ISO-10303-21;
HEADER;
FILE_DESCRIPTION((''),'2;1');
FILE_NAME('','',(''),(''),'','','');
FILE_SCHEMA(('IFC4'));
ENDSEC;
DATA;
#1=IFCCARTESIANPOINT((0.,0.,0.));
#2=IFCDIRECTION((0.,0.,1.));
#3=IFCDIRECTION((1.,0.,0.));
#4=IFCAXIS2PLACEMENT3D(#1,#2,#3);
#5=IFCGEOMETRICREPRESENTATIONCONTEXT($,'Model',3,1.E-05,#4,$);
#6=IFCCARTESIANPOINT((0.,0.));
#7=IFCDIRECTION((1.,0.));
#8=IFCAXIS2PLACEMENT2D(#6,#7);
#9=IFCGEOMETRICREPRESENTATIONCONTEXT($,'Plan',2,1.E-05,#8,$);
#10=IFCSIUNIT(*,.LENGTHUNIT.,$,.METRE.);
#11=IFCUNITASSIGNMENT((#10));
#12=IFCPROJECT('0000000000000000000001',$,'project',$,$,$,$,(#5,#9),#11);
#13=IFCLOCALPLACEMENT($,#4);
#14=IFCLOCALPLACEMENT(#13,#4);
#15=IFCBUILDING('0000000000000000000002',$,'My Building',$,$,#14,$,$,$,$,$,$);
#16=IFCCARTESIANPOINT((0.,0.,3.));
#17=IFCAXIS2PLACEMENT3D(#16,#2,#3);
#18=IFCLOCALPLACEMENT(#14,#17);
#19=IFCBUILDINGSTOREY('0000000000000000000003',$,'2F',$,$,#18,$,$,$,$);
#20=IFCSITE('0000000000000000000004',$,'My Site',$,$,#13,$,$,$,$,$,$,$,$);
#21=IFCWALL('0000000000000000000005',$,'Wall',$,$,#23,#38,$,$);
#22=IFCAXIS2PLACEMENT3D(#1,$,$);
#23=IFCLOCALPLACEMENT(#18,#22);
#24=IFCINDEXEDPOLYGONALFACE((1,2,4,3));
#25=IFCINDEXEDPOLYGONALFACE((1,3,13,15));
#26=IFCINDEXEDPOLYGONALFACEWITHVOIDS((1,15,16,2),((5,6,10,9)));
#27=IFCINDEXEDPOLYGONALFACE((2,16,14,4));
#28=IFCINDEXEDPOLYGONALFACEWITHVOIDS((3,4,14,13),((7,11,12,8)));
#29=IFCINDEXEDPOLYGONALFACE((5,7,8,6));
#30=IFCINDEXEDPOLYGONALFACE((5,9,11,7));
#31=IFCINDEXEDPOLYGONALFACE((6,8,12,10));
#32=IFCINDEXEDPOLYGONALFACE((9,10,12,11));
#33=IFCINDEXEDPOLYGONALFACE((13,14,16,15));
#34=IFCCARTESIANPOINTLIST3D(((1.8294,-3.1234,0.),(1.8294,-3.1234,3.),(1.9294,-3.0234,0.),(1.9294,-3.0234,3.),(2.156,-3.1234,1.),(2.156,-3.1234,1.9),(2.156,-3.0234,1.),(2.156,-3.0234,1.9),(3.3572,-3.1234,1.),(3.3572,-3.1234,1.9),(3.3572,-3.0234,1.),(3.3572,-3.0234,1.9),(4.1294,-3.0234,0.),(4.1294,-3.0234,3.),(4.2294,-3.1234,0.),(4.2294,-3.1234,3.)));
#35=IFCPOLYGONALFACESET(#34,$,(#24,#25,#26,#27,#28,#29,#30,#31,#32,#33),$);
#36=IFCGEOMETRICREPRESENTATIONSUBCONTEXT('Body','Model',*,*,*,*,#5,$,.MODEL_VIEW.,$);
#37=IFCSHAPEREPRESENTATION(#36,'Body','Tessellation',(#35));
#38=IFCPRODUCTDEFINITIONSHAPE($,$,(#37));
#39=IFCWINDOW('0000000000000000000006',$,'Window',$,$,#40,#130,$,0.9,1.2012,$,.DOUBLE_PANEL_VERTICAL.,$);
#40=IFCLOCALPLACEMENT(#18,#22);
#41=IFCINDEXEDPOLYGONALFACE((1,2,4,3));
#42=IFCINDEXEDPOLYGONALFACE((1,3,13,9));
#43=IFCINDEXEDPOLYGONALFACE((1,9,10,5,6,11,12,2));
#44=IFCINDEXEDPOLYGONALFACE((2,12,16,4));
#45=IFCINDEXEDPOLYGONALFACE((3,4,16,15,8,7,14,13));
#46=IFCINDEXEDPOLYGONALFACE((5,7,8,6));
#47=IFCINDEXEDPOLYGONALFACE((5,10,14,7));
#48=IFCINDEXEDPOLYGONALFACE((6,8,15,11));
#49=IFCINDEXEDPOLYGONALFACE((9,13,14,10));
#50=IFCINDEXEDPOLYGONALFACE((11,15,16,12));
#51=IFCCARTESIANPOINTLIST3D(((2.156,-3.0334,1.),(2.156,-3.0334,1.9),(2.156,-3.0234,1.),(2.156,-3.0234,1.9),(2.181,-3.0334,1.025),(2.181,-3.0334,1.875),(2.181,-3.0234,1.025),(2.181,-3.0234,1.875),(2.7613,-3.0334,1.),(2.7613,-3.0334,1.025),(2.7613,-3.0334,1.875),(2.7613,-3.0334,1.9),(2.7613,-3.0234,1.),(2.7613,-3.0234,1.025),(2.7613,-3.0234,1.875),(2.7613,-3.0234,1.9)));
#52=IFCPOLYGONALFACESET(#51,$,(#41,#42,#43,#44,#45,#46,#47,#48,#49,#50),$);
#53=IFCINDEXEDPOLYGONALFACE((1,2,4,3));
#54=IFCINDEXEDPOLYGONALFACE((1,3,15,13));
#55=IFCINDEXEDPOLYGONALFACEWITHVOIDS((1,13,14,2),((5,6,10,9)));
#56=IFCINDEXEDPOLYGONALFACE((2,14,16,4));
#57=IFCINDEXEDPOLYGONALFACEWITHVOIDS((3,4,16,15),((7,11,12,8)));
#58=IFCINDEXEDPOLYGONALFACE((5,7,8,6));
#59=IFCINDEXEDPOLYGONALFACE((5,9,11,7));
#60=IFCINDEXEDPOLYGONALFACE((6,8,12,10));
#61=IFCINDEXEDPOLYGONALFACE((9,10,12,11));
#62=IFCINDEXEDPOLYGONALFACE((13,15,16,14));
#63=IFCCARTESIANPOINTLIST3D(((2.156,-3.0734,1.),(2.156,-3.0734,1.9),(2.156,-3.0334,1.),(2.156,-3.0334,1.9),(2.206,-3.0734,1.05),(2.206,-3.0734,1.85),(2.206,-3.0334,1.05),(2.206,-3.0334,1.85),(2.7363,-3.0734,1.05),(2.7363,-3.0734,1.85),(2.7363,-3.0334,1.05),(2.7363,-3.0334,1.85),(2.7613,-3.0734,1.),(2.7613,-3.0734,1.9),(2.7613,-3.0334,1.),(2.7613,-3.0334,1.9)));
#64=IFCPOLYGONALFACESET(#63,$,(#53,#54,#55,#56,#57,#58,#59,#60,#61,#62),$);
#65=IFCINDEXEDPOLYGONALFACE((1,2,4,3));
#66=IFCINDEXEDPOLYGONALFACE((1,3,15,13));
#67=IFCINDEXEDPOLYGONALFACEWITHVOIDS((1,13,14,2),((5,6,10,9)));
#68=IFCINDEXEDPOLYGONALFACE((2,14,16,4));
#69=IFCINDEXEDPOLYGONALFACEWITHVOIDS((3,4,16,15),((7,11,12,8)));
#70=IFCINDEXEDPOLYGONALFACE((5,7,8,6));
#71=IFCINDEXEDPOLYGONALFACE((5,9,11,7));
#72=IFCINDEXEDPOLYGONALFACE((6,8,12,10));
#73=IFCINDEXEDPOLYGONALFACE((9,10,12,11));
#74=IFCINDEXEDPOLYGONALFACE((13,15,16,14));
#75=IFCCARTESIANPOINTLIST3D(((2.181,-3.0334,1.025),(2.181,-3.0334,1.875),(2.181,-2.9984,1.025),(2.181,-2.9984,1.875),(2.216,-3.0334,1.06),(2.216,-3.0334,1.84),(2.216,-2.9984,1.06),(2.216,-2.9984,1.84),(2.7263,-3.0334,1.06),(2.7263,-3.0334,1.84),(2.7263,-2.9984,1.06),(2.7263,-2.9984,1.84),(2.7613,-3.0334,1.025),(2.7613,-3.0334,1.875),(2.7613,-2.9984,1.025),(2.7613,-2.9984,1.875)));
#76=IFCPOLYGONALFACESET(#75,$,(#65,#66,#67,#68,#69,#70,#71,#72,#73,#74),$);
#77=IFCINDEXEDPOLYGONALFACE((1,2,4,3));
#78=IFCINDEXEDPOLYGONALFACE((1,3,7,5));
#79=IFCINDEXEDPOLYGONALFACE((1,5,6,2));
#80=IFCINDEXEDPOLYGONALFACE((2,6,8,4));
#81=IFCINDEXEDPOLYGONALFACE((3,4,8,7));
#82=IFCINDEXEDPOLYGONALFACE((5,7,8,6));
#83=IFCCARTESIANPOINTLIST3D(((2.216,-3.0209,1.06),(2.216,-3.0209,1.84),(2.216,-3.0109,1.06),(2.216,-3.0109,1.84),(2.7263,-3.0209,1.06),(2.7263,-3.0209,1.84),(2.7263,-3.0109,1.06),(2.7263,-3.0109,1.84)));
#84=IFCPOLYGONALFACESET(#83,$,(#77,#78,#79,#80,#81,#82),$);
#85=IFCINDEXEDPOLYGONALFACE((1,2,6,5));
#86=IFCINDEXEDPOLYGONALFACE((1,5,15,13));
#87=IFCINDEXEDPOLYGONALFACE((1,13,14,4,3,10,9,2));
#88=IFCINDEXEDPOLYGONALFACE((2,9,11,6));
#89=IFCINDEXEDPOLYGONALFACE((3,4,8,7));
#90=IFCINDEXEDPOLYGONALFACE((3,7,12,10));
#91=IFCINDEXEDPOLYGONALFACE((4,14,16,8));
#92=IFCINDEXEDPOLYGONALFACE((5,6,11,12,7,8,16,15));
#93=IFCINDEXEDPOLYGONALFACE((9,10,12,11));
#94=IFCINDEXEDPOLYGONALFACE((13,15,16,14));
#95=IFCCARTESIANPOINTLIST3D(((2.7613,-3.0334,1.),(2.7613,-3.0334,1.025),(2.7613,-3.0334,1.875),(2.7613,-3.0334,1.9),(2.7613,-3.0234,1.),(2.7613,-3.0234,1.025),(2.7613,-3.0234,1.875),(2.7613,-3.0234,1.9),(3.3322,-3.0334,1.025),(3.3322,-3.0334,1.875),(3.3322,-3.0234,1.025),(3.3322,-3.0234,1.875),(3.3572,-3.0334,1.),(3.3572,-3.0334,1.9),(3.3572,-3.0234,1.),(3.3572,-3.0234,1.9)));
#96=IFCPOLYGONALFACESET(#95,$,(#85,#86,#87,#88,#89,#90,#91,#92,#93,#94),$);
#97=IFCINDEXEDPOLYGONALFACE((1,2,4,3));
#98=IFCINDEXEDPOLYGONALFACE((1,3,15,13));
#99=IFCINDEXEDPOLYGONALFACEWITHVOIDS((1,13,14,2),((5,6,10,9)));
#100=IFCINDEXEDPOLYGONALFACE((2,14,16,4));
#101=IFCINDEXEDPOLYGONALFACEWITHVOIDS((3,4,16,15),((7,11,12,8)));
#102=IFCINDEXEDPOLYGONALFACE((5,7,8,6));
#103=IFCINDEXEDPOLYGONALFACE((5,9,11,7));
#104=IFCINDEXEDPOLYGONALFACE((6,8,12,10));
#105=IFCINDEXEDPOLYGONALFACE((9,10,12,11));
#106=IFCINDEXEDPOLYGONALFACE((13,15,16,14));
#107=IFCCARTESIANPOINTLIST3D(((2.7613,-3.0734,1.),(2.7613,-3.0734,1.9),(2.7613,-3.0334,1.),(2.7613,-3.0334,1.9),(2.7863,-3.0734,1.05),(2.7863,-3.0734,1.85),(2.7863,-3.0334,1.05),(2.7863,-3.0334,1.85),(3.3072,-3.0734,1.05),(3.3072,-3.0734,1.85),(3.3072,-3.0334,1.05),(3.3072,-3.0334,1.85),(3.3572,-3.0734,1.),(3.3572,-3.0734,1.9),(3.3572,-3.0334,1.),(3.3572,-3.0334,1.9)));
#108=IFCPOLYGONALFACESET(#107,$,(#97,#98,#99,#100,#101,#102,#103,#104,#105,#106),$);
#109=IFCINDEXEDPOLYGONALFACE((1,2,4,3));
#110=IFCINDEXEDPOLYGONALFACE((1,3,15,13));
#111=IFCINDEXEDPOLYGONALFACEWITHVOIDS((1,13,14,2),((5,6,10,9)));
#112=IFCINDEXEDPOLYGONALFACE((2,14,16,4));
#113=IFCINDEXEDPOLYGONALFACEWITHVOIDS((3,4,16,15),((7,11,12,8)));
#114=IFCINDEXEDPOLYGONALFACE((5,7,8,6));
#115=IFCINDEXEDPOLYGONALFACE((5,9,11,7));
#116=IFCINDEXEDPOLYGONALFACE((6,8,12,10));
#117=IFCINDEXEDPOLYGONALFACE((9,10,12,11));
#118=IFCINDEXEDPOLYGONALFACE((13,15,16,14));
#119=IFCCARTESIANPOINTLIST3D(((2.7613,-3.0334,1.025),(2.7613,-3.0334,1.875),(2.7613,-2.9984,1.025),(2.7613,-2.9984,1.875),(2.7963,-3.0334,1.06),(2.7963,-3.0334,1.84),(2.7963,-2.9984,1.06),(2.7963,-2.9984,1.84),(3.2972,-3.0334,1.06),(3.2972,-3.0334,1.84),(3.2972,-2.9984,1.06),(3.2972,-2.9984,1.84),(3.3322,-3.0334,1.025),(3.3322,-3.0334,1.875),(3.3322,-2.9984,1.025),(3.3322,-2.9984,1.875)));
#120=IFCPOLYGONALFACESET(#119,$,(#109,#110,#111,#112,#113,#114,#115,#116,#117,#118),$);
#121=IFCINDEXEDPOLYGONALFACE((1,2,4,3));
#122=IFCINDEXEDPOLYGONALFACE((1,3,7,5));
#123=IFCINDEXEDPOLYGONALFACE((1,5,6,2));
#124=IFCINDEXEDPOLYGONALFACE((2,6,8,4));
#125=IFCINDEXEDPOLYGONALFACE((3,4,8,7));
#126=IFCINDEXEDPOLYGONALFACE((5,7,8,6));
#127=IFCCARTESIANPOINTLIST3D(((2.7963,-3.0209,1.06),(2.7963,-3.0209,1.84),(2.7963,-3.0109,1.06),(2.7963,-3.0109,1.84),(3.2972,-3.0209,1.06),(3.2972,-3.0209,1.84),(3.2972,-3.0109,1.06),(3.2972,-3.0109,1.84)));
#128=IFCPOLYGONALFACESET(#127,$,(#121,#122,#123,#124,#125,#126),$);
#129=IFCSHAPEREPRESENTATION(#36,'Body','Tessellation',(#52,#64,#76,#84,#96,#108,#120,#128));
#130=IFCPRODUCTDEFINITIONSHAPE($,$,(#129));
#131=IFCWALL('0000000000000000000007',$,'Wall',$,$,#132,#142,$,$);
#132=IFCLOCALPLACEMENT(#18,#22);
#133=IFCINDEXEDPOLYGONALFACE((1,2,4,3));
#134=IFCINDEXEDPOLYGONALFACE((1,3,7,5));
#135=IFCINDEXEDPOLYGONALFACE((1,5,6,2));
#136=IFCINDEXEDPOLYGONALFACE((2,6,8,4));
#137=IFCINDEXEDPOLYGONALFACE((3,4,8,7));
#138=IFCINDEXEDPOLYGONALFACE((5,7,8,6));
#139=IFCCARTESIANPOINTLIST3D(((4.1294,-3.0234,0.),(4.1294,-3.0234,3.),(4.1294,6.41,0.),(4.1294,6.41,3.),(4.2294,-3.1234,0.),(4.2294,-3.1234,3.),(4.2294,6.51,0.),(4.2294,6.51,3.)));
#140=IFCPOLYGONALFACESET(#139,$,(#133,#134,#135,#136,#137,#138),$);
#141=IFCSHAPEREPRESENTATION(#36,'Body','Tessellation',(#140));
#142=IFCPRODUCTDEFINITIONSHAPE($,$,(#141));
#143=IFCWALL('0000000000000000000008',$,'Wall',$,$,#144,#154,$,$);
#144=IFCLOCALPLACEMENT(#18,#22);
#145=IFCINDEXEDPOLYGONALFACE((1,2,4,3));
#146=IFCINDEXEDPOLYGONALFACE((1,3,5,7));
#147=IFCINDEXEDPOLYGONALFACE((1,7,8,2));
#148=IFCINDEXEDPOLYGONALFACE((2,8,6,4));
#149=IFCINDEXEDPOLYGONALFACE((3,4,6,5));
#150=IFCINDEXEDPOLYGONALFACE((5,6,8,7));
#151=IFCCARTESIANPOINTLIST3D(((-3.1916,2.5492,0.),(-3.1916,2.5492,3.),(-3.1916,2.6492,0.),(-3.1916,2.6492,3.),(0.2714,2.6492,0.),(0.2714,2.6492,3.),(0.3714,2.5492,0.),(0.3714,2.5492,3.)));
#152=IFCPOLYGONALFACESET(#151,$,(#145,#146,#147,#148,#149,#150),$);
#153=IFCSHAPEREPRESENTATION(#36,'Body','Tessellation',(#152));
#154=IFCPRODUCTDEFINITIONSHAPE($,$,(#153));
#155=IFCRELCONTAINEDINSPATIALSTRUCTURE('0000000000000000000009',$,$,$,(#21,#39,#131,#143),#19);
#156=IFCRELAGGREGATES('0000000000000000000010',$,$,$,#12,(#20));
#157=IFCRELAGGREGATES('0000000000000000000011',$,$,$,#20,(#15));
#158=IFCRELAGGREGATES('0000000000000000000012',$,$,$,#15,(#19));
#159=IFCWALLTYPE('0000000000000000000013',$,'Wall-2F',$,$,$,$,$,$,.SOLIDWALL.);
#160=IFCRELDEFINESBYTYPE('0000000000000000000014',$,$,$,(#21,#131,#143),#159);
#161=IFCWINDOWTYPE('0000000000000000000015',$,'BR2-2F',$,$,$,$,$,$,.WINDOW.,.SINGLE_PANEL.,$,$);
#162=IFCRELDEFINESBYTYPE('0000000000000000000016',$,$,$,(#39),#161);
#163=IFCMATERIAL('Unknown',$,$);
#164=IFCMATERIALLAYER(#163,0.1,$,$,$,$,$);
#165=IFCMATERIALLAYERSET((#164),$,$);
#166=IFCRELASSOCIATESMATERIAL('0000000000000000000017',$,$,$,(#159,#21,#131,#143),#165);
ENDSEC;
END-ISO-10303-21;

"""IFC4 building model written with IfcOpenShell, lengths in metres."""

from ifc_helpers import new_model, entity, si_unit, frame, origin_with_axes, origin_2d_with_axis, place, context, subcontext, project, spatial, line, indexed_curve, outline, extrude, shape, source, transform, mapped, material, layer, layer_set, layer_usage, type_object, type_shapes, element, fill, save


model = new_model("IFC4")

# Units and contexts
model_context = context("Model", 3, precision=1e-05, world=origin_with_axes())
plan_context = context("Plan", 2, precision=1e-05, world=origin_2d_with_axis())
body_context_1 = subcontext(model_context, "Body", "Model", "MODEL_VIEW")
body_context_2 = subcontext(plan_context, "Body", "Plan", "PLAN_VIEW")
ifc_project = project(units=[si_unit("LENGTHUNIT", "METRE")], contexts=[model_context, plan_context])

# Site, building, storey
site_placement = place(None, origin_with_axes())
site = spatial("IfcSite", under=ifc_project, at=site_placement, Name="My Site")
building_placement = place(site_placement, origin_with_axes())
building = spatial("IfcBuilding", under=site, at=building_placement, Name="My Building")
storey_placement = place(building_placement, frame((0.0, 0.0, 3.0), z_axis=(0.0, 0.0, 1.0), x_axis=(1.0, 0.0, 0.0)))
storey = spatial("IfcBuildingStorey", under=building, at=storey_placement, Name="2F")

# Shared definitions
ifc_material = material(Name="Unknown")

# Shared definitions
ifc_layer = layer(ifc_material, 0.1)
ifc_layer_set = layer_set([ifc_layer])
wall_type = type_object("IfcWallType", Name="Wall-2F", PredefinedType="SOLIDWALL", material=ifc_layer_set)

# Wall, opening, window
ifc_layer_usage_1 = layer_usage(ifc_layer_set, "AXIS2", "POSITIVE", 0.0)
wall_1_placement = place(storey_placement, frame((1.8294, -3.1234, 0.0), z_axis=(0.0, 0.0, 1.0), x_axis=(1.0, 0.0, 0.0)))
wall_1 = element("IfcWall", 1, at=wall_1_placement, inside=storey, type_object=wall_type, material=ifc_layer_usage_1, Name="Wall", context=body_context_1, shape_type="SweptSolid", body=[
    extrude(outline(indexed_curve([(0.0, 0.0), (0.1, 0.1), (2.3, 0.1), (2.4, 0.0)], segments=[line(1, 2, 3, 4, 1)])), origin_with_axes(), (0.0, 0.0, 1.0), 3.0),
])
shared_shape_1 = source(origin_with_axes(), body_context_1, "Body", "SweptSolid", [
    extrude(outline(indexed_curve([(0.0, 0.0), (1.2012, 0.0), (1.2012, 0.9), (0.0, 0.9)], segments=[line(1, 2, 3, 4, 1)])), frame((0.0, -0.6, 0.0), z_axis=(0.0, -1.0, 0.0), x_axis=(1.0, 0.0, 0.0)), (0.0, 0.0, -1.0), 1.2),
])
opening_1_placement = place(wall_1_placement, frame((0.3266, 0.0, 1.0), z_axis=(0.0, 0.0, 1.0), x_axis=(1.0, 0.0, 0.0)))
opening_1 = element("IfcOpeningElement", 2, at=opening_1_placement, cuts=wall_1, PredefinedType="OPENING", context=body_context_1, shape_type="MappedRepresentation", body=[
    mapped(shared_shape_1, transform((0.0, 0.0, 0.0), x_axis=(1.0, 0.0, 0.0), y_axis=(0.0, 1.0, 0.0), z_axis=(0.0, 0.0, 1.0), scale=1.0)),
])
window_type = type_object("IfcWindowType", Name="BR2-2F", PartitioningType="SINGLE_PANEL", PredefinedType="WINDOW")
shared_shape_2 = source(origin_with_axes(), body_context_1, "Body", "SweptSolid", [
    extrude(outline(indexed_curve([(0.6053, 0.0), (0.0, 0.0), (0.0, 0.9), (0.6053, 0.9), (0.6053, 0.875), (0.025, 0.875), (0.025, 0.025), (0.6053, 0.025)], segments=[line(1, 2, 3, 4, 5, 6, 7, 8, 1)])), frame((0.0, 0.09, 0.0), z_axis=(0.0, -1.0, 0.0), x_axis=(1.0, 0.0, 0.0)), (0.0, 0.0, -1.0), 0.01),
    extrude(outline(indexed_curve([(0.0, 0.0), (0.6053, 0.0), (0.6053, 0.9), (0.0, 0.9)], segments=[line(1, 2, 3, 4, 1)]), holes=[indexed_curve([(0.05, 0.05), (0.5803, 0.05), (0.5803, 0.85), (0.05, 0.85)], segments=[line(1, 2, 3, 4, 1)])]), frame((0.0, 0.05, 0.0), z_axis=(0.0, -1.0, 0.0), x_axis=(1.0, 0.0, 0.0)), (0.0, 0.0, -1.0), 0.04),
    extrude(outline(indexed_curve([(0.0, 0.0), (0.5803, 0.0), (0.5803, 0.85), (0.0, 0.85)], segments=[line(1, 2, 3, 4, 1)]), holes=[indexed_curve([(0.035, 0.035), (0.5453, 0.035), (0.5453, 0.815), (0.035, 0.815)], segments=[line(1, 2, 3, 4, 1)])]), frame((0.025, 0.09, 0.025), z_axis=(0.0, -1.0, 0.0), x_axis=(1.0, 0.0, 0.0)), (0.0, 0.0, -1.0), 0.035),
    extrude(outline(indexed_curve([(0.035, 0.035), (0.5453, 0.035), (0.5453, 0.815), (0.035, 0.815)], segments=[line(1, 2, 3, 4, 1)])), frame((0.025, 0.1025, 0.025), z_axis=(0.0, -1.0, 0.0), x_axis=(1.0, 0.0, 0.0)), (0.0, 0.0, -1.0), 0.01),
    extrude(outline(indexed_curve([(0.0, 0.9), (0.5958, 0.9), (0.5958, 0.0), (0.0, 0.0), (0.0, 0.025), (0.5708, 0.025), (0.5708, 0.875), (0.0, 0.875)], segments=[line(1, 2, 3, 4, 5, 6, 7, 8, 1)])), frame((0.6053, 0.09, 0.0), z_axis=(0.0, -1.0, 0.0), x_axis=(1.0, 0.0, 0.0)), (0.0, 0.0, -1.0), 0.01),
    extrude(outline(indexed_curve([(0.0, 0.0), (0.5958, 0.0), (0.5958, 0.9), (0.0, 0.9)], segments=[line(1, 2, 3, 4, 1)]), holes=[indexed_curve([(0.025, 0.05), (0.5458, 0.05), (0.5458, 0.85), (0.025, 0.85)], segments=[line(1, 2, 3, 4, 1)])]), frame((0.6053, 0.05, 0.0), z_axis=(0.0, -1.0, 0.0), x_axis=(1.0, 0.0, 0.0)), (0.0, 0.0, -1.0), 0.04),
    extrude(outline(indexed_curve([(0.0, 0.0), (0.5708, 0.0), (0.5708, 0.85), (0.0, 0.85)], segments=[line(1, 2, 3, 4, 1)]), holes=[indexed_curve([(0.035, 0.035), (0.5358, 0.035), (0.5358, 0.815), (0.035, 0.815)], segments=[line(1, 2, 3, 4, 1)])]), frame((0.6053, 0.09, 0.025), z_axis=(0.0, -1.0, 0.0), x_axis=(1.0, 0.0, 0.0)), (0.0, 0.0, -1.0), 0.035),
    extrude(outline(indexed_curve([(0.035, 0.035), (0.5358, 0.035), (0.5358, 0.815), (0.035, 0.815)], segments=[line(1, 2, 3, 4, 1)])), frame((0.6053, 0.1025, 0.025), z_axis=(0.0, -1.0, 0.0), x_axis=(1.0, 0.0, 0.0)), (0.0, 0.0, -1.0), 0.01),
])
shared_shape_3 = source(origin_with_axes(), body_context_2, "Body", "Curve2D", [
    entity("IfcIndexedPolyCurve", entity("IfcCartesianPointList2D", [[0.05, 0.05], [0.5803, 0.05]])),
    entity("IfcIndexedPolyCurve", entity("IfcCartesianPointList2D", [[0.0, 0.1], [0.025, 0.1], [0.025, 0.09], [0.05, 0.09], [0.05, 0.05], [0.0, 0.05]]), [entity("IfcLineIndex", [1, 2, 3, 4, 5, 6, 1])]),
    entity("IfcIndexedPolyCurve", entity("IfcCartesianPointList2D", [[0.6053, 0.1], [0.6053, 0.1], [0.6053, 0.09], [0.5803, 0.09], [0.5803, 0.05], [0.6053, 0.05]])),
    entity("IfcIndexedPolyCurve", entity("IfcCartesianPointList2D", [[0.025, 0.09], [0.06, 0.09], [0.06, 0.125], [0.025, 0.125]]), [entity("IfcLineIndex", [1, 2, 3, 4, 1])]),
    entity("IfcIndexedPolyCurve", entity("IfcCartesianPointList2D", [[0.6053, 0.09], [0.5703, 0.09], [0.5703, 0.125], [0.6053, 0.125]]), [entity("IfcLineIndex", [1, 2, 3, 4, 1])]),
    entity("IfcIndexedPolyCurve", entity("IfcCartesianPointList2D", [[0.06, 0.09], [0.5703, 0.09]])),
    entity("IfcIndexedPolyCurve", entity("IfcCartesianPointList2D", [[0.06, 0.125], [0.5703, 0.125]])),
    entity("IfcIndexedPolyCurve", entity("IfcCartesianPointList2D", [[0.06, 0.1075], [0.5703, 0.1075]])),
    entity("IfcIndexedPolyCurve", entity("IfcCartesianPointList2D", [[0.6303, 0.05], [1.1512, 0.05]])),
    entity("IfcIndexedPolyCurve", entity("IfcCartesianPointList2D", [[0.6053, 0.1], [0.6053, 0.1], [0.6053, 0.09], [0.6303, 0.09], [0.6303, 0.05], [0.6053, 0.05]])),
    entity("IfcIndexedPolyCurve", entity("IfcCartesianPointList2D", [[1.2012, 0.1], [1.1762, 0.1], [1.1762, 0.09], [1.1512, 0.09], [1.1512, 0.05], [1.2012, 0.05]]), [entity("IfcLineIndex", [1, 2, 3, 4, 5, 6, 1])]),
    entity("IfcIndexedPolyCurve", entity("IfcCartesianPointList2D", [[0.6053, 0.09], [0.6403, 0.09], [0.6403, 0.125], [0.6053, 0.125]]), [entity("IfcLineIndex", [1, 2, 3, 4, 1])]),
    entity("IfcIndexedPolyCurve", entity("IfcCartesianPointList2D", [[1.1762, 0.09], [1.1412, 0.09], [1.1412, 0.125], [1.1762, 0.125]]), [entity("IfcLineIndex", [1, 2, 3, 4, 1])]),
    entity("IfcIndexedPolyCurve", entity("IfcCartesianPointList2D", [[0.6403, 0.09], [1.1412, 0.09]])),
    entity("IfcIndexedPolyCurve", entity("IfcCartesianPointList2D", [[0.6403, 0.125], [1.1412, 0.125]])),
    entity("IfcIndexedPolyCurve", entity("IfcCartesianPointList2D", [[0.6403, 0.1075], [1.1412, 0.1075]])),
])
type_shapes(window_type, [shared_shape_2, shared_shape_3])
window_placement = place(opening_1_placement, origin_with_axes())
window = element("IfcWindow", 3, at=window_placement, inside=storey, type_object=window_type, Name="Window", OverallHeight=0.9, OverallWidth=1.2012, PartitioningType="DOUBLE_PANEL_VERTICAL", shapes=[
    shape(body_context_1, "Body", "MappedRepresentation", [mapped(shared_shape_2, transform((0.0, 0.0, 0.0), x_axis=(1.0, 0.0, 0.0), y_axis=(0.0, 1.0, 0.0), z_axis=(0.0, 0.0, 1.0), scale=1.0))]),
    shape(body_context_2, "Body", "MappedRepresentation", [mapped(shared_shape_3, transform((0.0, 0.0, 0.0), x_axis=(1.0, 0.0, 0.0), y_axis=(0.0, 1.0, 0.0), z_axis=(0.0, 0.0, 1.0), scale=1.0))]),
])
fill(opening_1, window)

# Walls
ifc_layer_usage_2 = layer_usage(ifc_layer_set, "AXIS2", "POSITIVE", 0.0)
wall_2_placement = place(storey_placement, frame((4.2294, -3.1234, 0.0), z_axis=(0.0, 0.0, 1.0), x_axis=(0.0, 1.0, 0.0)))
element("IfcWall", 4, at=wall_2_placement, inside=storey, type_object=wall_type, material=ifc_layer_usage_2, Name="Wall", context=body_context_1, shape_type="SweptSolid", body=[
    extrude(outline(indexed_curve([(0.0, 0.0), (0.1, 0.1), (9.5334, 0.1), (9.6334, 0.0)], segments=[line(1, 2, 3, 4, 1)])), origin_with_axes(), (0.0, 0.0, 1.0), 3.0),
])
ifc_layer_usage_3 = layer_usage(ifc_layer_set, "AXIS2", "POSITIVE", 0.0)
wall_3_placement = place(storey_placement, frame((-3.1916, 2.5492, 0.0), z_axis=(0.0, 0.0, 1.0), x_axis=(1.0, 0.0, 0.0)))
element("IfcWall", 5, at=wall_3_placement, inside=storey, type_object=wall_type, material=ifc_layer_usage_3, Name="Wall", context=body_context_1, shape_type="SweptSolid", body=[
    extrude(outline(indexed_curve([(0.0, 0.0), (0.0, 0.1), (3.463, 0.1), (3.563, 0.0)], segments=[line(1, 2, 3, 4, 1)])), origin_with_axes(), (0.0, 0.0, 1.0), 3.0),
])

save(model, "model.ifc")
